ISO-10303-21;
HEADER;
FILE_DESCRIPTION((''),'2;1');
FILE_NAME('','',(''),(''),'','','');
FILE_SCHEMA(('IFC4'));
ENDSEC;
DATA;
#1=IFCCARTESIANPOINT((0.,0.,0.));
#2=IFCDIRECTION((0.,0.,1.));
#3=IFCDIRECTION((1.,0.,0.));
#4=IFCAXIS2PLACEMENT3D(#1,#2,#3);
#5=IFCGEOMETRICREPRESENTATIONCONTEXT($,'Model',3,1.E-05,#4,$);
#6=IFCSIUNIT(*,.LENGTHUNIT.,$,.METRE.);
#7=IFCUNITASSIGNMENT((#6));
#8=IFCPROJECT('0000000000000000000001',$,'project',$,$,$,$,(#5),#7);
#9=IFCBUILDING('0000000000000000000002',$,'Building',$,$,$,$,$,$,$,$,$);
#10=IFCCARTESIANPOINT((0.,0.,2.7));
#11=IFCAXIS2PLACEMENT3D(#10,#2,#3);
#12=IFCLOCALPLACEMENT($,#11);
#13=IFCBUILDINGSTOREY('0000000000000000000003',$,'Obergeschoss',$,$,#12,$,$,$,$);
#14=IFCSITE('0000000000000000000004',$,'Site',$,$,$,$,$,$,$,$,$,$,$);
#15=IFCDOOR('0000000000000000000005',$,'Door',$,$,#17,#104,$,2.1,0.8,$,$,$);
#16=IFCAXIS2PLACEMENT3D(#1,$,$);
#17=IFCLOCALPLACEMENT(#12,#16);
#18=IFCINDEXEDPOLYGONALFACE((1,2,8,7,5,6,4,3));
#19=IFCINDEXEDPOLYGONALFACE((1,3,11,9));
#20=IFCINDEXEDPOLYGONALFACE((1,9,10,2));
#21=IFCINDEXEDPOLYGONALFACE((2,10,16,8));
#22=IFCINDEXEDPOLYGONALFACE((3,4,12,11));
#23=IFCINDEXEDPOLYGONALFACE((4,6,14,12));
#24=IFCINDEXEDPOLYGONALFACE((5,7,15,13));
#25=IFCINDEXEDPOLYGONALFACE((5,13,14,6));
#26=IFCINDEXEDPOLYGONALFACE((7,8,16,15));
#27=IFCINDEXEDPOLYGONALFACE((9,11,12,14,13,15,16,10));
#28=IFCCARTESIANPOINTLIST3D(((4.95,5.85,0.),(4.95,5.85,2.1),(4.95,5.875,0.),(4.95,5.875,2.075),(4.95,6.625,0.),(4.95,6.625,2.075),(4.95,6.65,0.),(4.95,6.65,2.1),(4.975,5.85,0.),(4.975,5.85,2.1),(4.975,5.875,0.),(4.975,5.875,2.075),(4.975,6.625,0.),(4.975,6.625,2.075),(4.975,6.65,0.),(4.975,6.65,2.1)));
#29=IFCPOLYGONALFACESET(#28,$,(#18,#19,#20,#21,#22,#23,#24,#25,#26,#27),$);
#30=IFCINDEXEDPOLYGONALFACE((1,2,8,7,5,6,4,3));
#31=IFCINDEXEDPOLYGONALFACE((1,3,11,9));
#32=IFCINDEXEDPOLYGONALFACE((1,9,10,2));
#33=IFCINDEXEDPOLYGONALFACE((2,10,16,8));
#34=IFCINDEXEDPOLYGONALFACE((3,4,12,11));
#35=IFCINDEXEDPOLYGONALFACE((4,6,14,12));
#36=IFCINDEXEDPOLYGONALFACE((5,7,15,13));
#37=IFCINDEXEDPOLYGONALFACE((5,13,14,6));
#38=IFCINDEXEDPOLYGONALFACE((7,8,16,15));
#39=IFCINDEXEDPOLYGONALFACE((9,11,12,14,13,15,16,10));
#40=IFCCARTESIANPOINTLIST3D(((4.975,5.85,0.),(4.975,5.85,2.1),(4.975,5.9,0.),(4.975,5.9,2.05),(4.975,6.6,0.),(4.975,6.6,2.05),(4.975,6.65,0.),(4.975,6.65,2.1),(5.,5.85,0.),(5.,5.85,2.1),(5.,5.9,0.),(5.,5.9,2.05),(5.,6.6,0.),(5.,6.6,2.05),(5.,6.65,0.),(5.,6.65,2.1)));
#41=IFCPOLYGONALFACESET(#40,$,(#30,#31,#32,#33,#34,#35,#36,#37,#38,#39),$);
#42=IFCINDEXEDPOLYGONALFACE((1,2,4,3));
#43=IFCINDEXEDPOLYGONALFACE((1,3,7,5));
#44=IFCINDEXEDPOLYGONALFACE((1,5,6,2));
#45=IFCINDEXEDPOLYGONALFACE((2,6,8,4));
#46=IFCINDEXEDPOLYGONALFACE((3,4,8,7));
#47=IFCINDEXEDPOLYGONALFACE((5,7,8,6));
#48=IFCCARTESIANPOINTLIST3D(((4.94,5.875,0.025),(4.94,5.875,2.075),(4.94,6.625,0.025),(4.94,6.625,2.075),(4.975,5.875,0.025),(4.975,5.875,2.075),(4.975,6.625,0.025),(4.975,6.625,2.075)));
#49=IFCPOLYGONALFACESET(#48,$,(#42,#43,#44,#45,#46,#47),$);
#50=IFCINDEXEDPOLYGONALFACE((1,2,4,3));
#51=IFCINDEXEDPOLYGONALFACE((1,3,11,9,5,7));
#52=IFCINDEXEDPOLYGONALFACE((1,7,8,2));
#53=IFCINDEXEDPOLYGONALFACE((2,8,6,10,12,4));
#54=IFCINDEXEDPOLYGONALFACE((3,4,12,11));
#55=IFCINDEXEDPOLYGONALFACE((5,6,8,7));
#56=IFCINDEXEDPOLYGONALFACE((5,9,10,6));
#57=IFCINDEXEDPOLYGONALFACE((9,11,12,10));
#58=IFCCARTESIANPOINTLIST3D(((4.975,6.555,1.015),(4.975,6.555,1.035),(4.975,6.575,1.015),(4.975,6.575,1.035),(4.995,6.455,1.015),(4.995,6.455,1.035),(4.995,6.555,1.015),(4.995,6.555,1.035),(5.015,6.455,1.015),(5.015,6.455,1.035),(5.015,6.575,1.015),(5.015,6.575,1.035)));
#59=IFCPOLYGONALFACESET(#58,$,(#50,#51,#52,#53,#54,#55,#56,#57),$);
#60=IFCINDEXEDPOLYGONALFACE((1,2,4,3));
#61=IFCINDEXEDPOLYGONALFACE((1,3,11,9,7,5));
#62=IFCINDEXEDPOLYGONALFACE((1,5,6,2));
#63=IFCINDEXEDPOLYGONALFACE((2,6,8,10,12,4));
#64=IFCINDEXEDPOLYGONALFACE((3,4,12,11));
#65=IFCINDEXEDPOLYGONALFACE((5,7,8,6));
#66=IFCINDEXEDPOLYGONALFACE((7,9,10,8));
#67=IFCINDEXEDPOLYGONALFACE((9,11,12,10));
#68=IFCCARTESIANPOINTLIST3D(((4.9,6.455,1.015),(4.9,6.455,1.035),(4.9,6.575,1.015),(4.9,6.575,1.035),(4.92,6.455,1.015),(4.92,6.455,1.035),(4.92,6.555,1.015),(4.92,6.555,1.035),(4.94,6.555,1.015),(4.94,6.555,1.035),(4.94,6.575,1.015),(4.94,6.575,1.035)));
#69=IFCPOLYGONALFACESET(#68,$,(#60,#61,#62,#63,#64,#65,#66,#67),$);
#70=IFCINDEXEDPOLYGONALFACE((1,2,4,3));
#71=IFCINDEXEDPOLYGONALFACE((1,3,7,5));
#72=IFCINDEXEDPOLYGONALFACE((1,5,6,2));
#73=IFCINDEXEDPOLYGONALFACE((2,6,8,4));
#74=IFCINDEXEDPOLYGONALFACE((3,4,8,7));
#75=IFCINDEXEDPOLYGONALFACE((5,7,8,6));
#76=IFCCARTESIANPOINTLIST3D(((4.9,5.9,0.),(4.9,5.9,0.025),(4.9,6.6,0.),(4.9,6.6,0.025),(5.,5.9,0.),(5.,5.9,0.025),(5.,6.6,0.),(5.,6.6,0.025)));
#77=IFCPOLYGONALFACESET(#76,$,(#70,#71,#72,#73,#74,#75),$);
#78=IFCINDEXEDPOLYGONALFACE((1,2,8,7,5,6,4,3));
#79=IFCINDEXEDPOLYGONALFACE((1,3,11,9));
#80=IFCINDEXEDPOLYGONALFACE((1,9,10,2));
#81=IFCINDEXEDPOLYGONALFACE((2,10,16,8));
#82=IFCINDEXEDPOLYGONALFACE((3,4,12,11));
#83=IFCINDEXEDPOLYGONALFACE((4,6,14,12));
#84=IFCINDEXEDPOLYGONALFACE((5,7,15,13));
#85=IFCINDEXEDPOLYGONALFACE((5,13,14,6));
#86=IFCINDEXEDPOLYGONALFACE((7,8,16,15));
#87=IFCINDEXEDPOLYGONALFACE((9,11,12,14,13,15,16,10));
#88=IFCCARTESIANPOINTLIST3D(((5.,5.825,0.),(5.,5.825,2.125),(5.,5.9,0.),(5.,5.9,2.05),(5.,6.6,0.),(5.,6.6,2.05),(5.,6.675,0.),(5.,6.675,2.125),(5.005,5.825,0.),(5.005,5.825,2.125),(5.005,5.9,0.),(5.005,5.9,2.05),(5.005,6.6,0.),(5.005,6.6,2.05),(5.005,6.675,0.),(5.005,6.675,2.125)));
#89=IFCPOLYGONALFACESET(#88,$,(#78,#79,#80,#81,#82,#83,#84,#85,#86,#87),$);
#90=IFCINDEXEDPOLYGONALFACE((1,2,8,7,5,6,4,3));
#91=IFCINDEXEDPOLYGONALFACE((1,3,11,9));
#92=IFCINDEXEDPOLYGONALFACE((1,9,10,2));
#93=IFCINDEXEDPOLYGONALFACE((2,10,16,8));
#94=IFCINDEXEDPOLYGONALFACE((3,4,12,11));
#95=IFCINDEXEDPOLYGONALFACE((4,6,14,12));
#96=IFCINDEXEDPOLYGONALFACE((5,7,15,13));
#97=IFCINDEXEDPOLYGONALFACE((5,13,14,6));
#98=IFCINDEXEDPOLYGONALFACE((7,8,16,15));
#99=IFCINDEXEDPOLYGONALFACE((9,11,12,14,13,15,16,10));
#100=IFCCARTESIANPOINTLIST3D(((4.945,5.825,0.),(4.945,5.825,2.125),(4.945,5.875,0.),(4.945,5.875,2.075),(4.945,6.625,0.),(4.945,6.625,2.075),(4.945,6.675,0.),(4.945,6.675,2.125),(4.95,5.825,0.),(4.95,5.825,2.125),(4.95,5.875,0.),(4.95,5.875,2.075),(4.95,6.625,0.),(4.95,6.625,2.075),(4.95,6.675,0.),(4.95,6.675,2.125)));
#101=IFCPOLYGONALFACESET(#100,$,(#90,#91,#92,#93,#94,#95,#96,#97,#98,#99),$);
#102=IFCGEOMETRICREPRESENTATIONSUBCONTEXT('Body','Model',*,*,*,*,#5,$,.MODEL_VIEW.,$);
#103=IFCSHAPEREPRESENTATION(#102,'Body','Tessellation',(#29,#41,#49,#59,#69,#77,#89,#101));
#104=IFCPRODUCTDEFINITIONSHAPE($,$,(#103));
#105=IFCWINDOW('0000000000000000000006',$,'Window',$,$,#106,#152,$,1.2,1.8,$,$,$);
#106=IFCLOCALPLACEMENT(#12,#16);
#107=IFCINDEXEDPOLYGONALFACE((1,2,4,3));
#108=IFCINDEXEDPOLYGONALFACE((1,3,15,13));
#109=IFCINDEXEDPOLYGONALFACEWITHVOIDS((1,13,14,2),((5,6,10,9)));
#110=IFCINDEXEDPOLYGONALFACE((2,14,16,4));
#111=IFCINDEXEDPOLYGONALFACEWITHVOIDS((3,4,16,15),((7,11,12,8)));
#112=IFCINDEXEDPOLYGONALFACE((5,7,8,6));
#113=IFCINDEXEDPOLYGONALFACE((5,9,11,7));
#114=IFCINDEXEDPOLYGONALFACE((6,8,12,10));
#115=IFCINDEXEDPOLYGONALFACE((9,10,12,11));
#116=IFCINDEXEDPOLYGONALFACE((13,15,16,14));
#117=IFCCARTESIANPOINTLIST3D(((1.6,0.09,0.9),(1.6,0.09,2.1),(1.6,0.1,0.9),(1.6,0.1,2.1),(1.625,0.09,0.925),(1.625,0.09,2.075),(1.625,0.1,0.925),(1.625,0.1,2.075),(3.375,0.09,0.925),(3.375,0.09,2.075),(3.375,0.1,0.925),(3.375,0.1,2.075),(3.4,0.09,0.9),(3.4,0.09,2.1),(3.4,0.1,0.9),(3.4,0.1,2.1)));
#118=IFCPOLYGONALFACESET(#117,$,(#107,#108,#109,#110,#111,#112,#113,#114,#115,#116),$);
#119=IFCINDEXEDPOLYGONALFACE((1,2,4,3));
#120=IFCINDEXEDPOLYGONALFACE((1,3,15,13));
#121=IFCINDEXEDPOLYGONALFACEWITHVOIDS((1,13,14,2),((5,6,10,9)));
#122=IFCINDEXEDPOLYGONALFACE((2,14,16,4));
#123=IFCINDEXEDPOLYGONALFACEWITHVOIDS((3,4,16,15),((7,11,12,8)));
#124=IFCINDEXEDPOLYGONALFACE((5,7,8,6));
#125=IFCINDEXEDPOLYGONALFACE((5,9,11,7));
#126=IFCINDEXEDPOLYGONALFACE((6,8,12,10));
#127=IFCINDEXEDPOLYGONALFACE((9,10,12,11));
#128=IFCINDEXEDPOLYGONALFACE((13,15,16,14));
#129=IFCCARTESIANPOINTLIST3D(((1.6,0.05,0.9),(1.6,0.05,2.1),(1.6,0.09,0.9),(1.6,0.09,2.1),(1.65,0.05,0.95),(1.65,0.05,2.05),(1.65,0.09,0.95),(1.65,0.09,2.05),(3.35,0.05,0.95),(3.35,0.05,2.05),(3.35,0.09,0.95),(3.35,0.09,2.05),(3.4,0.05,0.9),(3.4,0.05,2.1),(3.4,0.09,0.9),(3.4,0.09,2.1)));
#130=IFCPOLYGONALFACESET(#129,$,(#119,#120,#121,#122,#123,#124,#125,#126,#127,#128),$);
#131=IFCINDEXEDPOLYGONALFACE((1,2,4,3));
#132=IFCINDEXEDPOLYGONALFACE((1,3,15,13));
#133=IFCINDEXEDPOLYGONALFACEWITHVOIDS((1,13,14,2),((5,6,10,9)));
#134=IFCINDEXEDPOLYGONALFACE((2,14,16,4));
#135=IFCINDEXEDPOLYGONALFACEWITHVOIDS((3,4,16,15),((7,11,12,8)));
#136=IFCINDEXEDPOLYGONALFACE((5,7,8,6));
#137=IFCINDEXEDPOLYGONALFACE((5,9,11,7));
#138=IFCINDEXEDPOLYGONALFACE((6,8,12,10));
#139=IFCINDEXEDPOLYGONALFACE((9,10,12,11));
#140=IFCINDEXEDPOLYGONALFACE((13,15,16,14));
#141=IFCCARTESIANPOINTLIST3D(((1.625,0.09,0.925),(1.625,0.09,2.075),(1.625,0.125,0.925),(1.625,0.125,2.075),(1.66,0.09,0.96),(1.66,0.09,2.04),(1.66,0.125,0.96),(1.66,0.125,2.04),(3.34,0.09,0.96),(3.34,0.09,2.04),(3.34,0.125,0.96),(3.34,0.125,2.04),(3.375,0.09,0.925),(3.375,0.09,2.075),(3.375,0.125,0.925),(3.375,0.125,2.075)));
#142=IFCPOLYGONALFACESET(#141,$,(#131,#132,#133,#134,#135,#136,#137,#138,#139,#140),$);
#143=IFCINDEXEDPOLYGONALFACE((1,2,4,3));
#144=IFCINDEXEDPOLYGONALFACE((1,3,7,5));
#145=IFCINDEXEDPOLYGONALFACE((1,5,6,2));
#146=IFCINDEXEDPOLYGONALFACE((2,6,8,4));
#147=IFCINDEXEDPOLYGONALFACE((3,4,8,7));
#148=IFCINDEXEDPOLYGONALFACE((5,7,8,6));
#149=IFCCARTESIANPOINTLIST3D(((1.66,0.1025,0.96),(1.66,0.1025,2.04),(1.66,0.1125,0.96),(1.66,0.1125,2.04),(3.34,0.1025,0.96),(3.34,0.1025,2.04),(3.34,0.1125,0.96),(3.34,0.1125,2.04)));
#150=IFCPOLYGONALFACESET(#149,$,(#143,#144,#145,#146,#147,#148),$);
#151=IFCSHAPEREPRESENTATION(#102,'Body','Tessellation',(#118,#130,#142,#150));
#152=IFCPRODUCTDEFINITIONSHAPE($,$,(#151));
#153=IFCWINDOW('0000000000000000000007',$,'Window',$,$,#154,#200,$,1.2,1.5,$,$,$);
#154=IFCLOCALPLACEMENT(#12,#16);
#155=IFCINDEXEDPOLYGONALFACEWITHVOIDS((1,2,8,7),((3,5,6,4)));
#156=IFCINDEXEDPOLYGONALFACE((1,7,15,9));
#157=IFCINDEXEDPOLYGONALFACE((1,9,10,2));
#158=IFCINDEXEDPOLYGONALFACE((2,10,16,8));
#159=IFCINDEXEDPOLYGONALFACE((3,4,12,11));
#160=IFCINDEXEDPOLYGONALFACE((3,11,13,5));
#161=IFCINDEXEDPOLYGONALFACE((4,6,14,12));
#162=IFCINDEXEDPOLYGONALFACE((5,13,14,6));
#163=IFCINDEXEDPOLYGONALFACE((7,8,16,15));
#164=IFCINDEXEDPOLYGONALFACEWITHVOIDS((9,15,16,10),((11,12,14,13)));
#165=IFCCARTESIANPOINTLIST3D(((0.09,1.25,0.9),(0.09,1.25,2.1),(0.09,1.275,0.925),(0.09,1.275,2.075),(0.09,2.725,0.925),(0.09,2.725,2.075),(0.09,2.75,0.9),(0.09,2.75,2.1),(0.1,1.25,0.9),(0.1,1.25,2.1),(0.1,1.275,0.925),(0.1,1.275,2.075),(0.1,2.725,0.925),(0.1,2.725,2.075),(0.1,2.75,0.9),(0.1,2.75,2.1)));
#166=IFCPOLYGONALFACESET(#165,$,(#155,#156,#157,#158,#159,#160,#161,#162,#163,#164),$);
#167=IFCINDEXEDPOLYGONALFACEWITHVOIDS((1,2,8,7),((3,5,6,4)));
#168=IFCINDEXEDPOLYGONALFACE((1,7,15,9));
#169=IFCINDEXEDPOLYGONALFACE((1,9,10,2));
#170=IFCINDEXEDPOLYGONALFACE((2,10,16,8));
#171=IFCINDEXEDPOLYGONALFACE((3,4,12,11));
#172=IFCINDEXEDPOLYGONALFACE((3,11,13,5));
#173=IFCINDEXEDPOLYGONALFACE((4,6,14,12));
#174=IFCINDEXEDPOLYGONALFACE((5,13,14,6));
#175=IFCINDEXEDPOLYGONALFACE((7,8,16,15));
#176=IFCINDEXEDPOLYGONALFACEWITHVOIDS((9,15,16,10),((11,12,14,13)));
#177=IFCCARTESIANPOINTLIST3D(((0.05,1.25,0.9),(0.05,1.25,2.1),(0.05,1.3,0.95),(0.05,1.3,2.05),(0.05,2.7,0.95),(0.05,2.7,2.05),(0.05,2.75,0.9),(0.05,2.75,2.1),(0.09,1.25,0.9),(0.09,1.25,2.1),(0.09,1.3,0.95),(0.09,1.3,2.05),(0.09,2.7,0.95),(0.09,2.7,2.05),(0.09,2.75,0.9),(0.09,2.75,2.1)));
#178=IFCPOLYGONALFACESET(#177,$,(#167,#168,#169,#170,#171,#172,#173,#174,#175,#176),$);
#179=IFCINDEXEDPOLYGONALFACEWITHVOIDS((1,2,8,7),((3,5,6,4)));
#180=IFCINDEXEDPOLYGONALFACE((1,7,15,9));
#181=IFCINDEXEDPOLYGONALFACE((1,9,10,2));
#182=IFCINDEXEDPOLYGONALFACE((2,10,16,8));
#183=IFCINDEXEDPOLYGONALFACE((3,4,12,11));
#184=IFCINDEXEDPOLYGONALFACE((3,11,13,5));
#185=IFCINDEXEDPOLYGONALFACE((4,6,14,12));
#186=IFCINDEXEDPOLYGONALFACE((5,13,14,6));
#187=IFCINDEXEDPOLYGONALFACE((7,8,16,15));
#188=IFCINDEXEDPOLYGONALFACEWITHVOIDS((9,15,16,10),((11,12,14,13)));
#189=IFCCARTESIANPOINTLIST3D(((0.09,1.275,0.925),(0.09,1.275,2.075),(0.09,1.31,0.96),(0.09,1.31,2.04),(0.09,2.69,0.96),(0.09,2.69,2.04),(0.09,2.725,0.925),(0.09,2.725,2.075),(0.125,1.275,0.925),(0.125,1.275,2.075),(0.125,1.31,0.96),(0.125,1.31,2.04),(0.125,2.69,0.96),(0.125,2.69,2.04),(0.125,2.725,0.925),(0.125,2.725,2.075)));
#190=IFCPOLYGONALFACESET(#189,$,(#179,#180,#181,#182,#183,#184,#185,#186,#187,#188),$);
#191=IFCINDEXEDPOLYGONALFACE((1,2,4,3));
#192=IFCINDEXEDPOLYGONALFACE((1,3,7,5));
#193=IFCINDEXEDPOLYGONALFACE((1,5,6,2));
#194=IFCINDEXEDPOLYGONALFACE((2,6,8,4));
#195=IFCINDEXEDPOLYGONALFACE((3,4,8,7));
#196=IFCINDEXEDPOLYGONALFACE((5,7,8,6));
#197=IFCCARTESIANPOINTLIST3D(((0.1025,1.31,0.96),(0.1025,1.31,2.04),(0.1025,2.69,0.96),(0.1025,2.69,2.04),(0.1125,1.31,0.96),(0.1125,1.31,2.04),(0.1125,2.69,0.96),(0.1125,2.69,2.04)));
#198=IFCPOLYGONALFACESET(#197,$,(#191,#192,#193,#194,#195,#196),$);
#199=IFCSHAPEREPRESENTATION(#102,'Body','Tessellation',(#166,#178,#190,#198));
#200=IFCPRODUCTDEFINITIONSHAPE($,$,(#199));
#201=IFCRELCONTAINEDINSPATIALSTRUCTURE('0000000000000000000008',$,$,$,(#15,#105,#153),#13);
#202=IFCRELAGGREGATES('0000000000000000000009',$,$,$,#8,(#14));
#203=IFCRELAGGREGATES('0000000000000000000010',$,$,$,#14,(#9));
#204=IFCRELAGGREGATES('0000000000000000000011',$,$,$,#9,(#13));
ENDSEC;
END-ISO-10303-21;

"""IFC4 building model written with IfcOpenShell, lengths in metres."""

from ifc_helpers import new_model, si_unit, frame, origin_with_axes, place, context, subcontext, project, spatial, line, indexed_curve, outline, extrude, element, save


model = new_model("IFC4")

# Units and contexts
model_context = context("Model", 3, precision=1e-05, world=origin_with_axes())
body_context = subcontext(model_context, "Body", "Model", "MODEL_VIEW")
ifc_project = project(units=[si_unit("LENGTHUNIT", "METRE")], contexts=[model_context])

# Site, building, storey
site = spatial("IfcSite", under=ifc_project, Name="Site")
building = spatial("IfcBuilding", under=site, Name="Building")
storey_placement = place(None, frame((0.0, 0.0, 2.7), z_axis=(0.0, 0.0, 1.0), x_axis=(1.0, 0.0, 0.0)))
storey = spatial("IfcBuildingStorey", under=building, at=storey_placement, Name="Obergeschoss")

# Door
door_1_placement = place(storey_placement, frame((5.0, 5.85, 0.0), z_axis=(0.0, 0.0, 1.0), x_axis=(0.0, 1.0, 0.0)))
element("IfcDoor", 1, at=door_1_placement, inside=storey, Name="Door", OverallHeight=2.1, OverallWidth=0.8, context=body_context, shape_type="SweptSolid", body=[
    extrude(outline(indexed_curve([(0.0, 0.0), (0.0, 2.1), (0.8, 2.1), (0.8, 0.0), (0.775, 0.0), (0.775, 2.075), (0.025, 2.075), (0.025, 0.0)], segments=[line(1, 2, 3, 4, 5, 6, 7, 8, 1)])), frame((0.0, 0.025, 0.0), z_axis=(0.0, -1.0, 0.0), x_axis=(1.0, 0.0, 0.0)), (0.0, 0.0, -1.0), 0.025),
    extrude(outline(indexed_curve([(0.0, 0.0), (0.0, 2.1), (0.8, 2.1), (0.8, 0.0), (0.75, 0.0), (0.75, 2.05), (0.05, 2.05), (0.05, 0.0)], segments=[line(1, 2, 3, 4, 5, 6, 7, 8, 1)])), frame((0.0, 0.0, 0.0), z_axis=(0.0, -1.0, 0.0), x_axis=(1.0, 0.0, 0.0)), (0.0, 0.0, -1.0), 0.025),
    extrude(outline(indexed_curve([(0.0, 0.0), (0.75, 0.0), (0.75, 0.035), (0.0, 0.035)], segments=[line(1, 2, 3, 4, 1)])), frame((0.025, 0.025, 0.025), z_axis=(0.0, 0.0, 1.0), x_axis=(1.0, 0.0, 0.0)), (0.0, 0.0, 1.0), 2.05),
    extrude(outline(indexed_curve([(0.0, 0.0), (0.0, -0.04), (-0.12, -0.04), (-0.12, -0.02), (-0.02, -0.02), (-0.02, 0.0)], segments=[line(1, 2, 3, 4, 5, 6, 1)])), frame((0.725, 0.025, 1.015), z_axis=(0.0, 0.0, 1.0), x_axis=(1.0, 0.0, 0.0)), (0.0, 0.0, 1.0), 0.02),
    extrude(outline(indexed_curve([(0.0, 0.0), (0.0, 0.04), (-0.12, 0.04), (-0.12, 0.02), (-0.02, 0.02), (-0.02, 0.0)], segments=[line(1, 2, 3, 4, 5, 6, 1)])), frame((0.725, 0.06, 1.015), z_axis=(0.0, 0.0, 1.0), x_axis=(1.0, 0.0, 0.0)), (0.0, 0.0, 1.0), 0.02),
    extrude(outline(indexed_curve([(0.0, 0.0), (0.7, 0.0), (0.7, 0.1), (0.0, 0.1)], segments=[line(1, 2, 3, 4, 1)])), frame((0.05, 0.0, 0.0), z_axis=(0.0, 0.0, 1.0), x_axis=(1.0, 0.0, 0.0)), (0.0, 0.0, 1.0), 0.025),
    extrude(outline(indexed_curve([(0.0, 0.0), (0.0, 2.125), (0.85, 2.125), (0.85, 0.0), (0.775, 0.0), (0.775, 2.05), (0.075, 2.05), (0.075, 0.0)], segments=[line(1, 2, 3, 4, 5, 6, 7, 8, 1)])), frame((-0.025, -0.005, 0.0), z_axis=(0.0, -1.0, 0.0), x_axis=(1.0, 0.0, 0.0)), (0.0, 0.0, -1.0), 0.005),
    extrude(outline(indexed_curve([(0.0, 0.0), (0.0, 2.125), (0.85, 2.125), (0.85, 0.0), (0.8, 0.0), (0.8, 2.075), (0.05, 2.075), (0.05, 0.0)], segments=[line(1, 2, 3, 4, 5, 6, 7, 8, 1)])), frame((-0.025, 0.05, 0.0), z_axis=(0.0, -1.0, 0.0), x_axis=(1.0, 0.0, 0.0)), (0.0, 0.0, -1.0), 0.005),
])

# Windows
window_1_placement = place(storey_placement, frame((1.6, 0.0, 0.9), z_axis=(0.0, 0.0, 1.0), x_axis=(1.0, 0.0, 0.0)))
element("IfcWindow", 2, at=window_1_placement, inside=storey, Name="Window", OverallHeight=1.2, OverallWidth=1.8, context=body_context, shape_type="SweptSolid", body=[
    extrude(outline(indexed_curve([(0.0, 0.0), (1.8, 0.0), (1.8, 1.2), (0.0, 1.2)], segments=[line(1, 2, 3, 4, 1)]), holes=[indexed_curve([(0.025, 0.025), (1.775, 0.025), (1.775, 1.175), (0.025, 1.175)], segments=[line(1, 2, 3, 4, 1)])]), frame((0.0, 0.09, 0.0), z_axis=(0.0, -1.0, 0.0), x_axis=(1.0, 0.0, 0.0)), (0.0, 0.0, -1.0), 0.01),
    extrude(outline(indexed_curve([(0.0, 0.0), (1.8, 0.0), (1.8, 1.2), (0.0, 1.2)], segments=[line(1, 2, 3, 4, 1)]), holes=[indexed_curve([(0.05, 0.05), (1.75, 0.05), (1.75, 1.15), (0.05, 1.15)], segments=[line(1, 2, 3, 4, 1)])]), frame((0.0, 0.05, 0.0), z_axis=(0.0, -1.0, 0.0), x_axis=(1.0, 0.0, 0.0)), (0.0, 0.0, -1.0), 0.04),
    extrude(outline(indexed_curve([(0.0, 0.0), (1.75, 0.0), (1.75, 1.15), (0.0, 1.15)], segments=[line(1, 2, 3, 4, 1)]), holes=[indexed_curve([(0.035, 0.035), (1.715, 0.035), (1.715, 1.115), (0.035, 1.115)], segments=[line(1, 2, 3, 4, 1)])]), frame((0.025, 0.09, 0.025), z_axis=(0.0, -1.0, 0.0), x_axis=(1.0, 0.0, 0.0)), (0.0, 0.0, -1.0), 0.035),
    extrude(outline(indexed_curve([(0.035, 0.035), (1.715, 0.035), (1.715, 1.115), (0.035, 1.115)], segments=[line(1, 2, 3, 4, 1)])), frame((0.025, 0.1025, 0.025), z_axis=(0.0, -1.0, 0.0), x_axis=(1.0, 0.0, 0.0)), (0.0, 0.0, -1.0), 0.01),
])
window_2_placement = place(storey_placement, frame((0.0, 2.75, 0.9), z_axis=(0.0, 0.0, 1.0), x_axis=(0.0, -1.0, 0.0)))
element("IfcWindow", 3, at=window_2_placement, inside=storey, Name="Window", OverallHeight=1.2, OverallWidth=1.5, context=body_context, shape_type="SweptSolid", body=[
    extrude(outline(indexed_curve([(0.0, 0.0), (1.5, 0.0), (1.5, 1.2), (0.0, 1.2)], segments=[line(1, 2, 3, 4, 1)]), holes=[indexed_curve([(0.025, 0.025), (1.475, 0.025), (1.475, 1.175), (0.025, 1.175)], segments=[line(1, 2, 3, 4, 1)])]), frame((0.0, 0.09, 0.0), z_axis=(0.0, -1.0, 0.0), x_axis=(1.0, 0.0, 0.0)), (0.0, 0.0, -1.0), 0.01),
    extrude(outline(indexed_curve([(0.0, 0.0), (1.5, 0.0), (1.5, 1.2), (0.0, 1.2)], segments=[line(1, 2, 3, 4, 1)]), holes=[indexed_curve([(0.05, 0.05), (1.45, 0.05), (1.45, 1.15), (0.05, 1.15)], segments=[line(1, 2, 3, 4, 1)])]), frame((0.0, 0.05, 0.0), z_axis=(0.0, -1.0, 0.0), x_axis=(1.0, 0.0, 0.0)), (0.0, 0.0, -1.0), 0.04),
    extrude(outline(indexed_curve([(0.0, 0.0), (1.45, 0.0), (1.45, 1.15), (0.0, 1.15)], segments=[line(1, 2, 3, 4, 1)]), holes=[indexed_curve([(0.035, 0.035), (1.415, 0.035), (1.415, 1.115), (0.035, 1.115)], segments=[line(1, 2, 3, 4, 1)])]), frame((0.025, 0.09, 0.025), z_axis=(0.0, -1.0, 0.0), x_axis=(1.0, 0.0, 0.0)), (0.0, 0.0, -1.0), 0.035),
    extrude(outline(indexed_curve([(0.035, 0.035), (1.415, 0.035), (1.415, 1.115), (0.035, 1.115)], segments=[line(1, 2, 3, 4, 1)])), frame((0.025, 0.1025, 0.025), z_axis=(0.0, -1.0, 0.0), x_axis=(1.0, 0.0, 0.0)), (0.0, 0.0, -1.0), 0.01),
])

save(model, "model.ifc")
